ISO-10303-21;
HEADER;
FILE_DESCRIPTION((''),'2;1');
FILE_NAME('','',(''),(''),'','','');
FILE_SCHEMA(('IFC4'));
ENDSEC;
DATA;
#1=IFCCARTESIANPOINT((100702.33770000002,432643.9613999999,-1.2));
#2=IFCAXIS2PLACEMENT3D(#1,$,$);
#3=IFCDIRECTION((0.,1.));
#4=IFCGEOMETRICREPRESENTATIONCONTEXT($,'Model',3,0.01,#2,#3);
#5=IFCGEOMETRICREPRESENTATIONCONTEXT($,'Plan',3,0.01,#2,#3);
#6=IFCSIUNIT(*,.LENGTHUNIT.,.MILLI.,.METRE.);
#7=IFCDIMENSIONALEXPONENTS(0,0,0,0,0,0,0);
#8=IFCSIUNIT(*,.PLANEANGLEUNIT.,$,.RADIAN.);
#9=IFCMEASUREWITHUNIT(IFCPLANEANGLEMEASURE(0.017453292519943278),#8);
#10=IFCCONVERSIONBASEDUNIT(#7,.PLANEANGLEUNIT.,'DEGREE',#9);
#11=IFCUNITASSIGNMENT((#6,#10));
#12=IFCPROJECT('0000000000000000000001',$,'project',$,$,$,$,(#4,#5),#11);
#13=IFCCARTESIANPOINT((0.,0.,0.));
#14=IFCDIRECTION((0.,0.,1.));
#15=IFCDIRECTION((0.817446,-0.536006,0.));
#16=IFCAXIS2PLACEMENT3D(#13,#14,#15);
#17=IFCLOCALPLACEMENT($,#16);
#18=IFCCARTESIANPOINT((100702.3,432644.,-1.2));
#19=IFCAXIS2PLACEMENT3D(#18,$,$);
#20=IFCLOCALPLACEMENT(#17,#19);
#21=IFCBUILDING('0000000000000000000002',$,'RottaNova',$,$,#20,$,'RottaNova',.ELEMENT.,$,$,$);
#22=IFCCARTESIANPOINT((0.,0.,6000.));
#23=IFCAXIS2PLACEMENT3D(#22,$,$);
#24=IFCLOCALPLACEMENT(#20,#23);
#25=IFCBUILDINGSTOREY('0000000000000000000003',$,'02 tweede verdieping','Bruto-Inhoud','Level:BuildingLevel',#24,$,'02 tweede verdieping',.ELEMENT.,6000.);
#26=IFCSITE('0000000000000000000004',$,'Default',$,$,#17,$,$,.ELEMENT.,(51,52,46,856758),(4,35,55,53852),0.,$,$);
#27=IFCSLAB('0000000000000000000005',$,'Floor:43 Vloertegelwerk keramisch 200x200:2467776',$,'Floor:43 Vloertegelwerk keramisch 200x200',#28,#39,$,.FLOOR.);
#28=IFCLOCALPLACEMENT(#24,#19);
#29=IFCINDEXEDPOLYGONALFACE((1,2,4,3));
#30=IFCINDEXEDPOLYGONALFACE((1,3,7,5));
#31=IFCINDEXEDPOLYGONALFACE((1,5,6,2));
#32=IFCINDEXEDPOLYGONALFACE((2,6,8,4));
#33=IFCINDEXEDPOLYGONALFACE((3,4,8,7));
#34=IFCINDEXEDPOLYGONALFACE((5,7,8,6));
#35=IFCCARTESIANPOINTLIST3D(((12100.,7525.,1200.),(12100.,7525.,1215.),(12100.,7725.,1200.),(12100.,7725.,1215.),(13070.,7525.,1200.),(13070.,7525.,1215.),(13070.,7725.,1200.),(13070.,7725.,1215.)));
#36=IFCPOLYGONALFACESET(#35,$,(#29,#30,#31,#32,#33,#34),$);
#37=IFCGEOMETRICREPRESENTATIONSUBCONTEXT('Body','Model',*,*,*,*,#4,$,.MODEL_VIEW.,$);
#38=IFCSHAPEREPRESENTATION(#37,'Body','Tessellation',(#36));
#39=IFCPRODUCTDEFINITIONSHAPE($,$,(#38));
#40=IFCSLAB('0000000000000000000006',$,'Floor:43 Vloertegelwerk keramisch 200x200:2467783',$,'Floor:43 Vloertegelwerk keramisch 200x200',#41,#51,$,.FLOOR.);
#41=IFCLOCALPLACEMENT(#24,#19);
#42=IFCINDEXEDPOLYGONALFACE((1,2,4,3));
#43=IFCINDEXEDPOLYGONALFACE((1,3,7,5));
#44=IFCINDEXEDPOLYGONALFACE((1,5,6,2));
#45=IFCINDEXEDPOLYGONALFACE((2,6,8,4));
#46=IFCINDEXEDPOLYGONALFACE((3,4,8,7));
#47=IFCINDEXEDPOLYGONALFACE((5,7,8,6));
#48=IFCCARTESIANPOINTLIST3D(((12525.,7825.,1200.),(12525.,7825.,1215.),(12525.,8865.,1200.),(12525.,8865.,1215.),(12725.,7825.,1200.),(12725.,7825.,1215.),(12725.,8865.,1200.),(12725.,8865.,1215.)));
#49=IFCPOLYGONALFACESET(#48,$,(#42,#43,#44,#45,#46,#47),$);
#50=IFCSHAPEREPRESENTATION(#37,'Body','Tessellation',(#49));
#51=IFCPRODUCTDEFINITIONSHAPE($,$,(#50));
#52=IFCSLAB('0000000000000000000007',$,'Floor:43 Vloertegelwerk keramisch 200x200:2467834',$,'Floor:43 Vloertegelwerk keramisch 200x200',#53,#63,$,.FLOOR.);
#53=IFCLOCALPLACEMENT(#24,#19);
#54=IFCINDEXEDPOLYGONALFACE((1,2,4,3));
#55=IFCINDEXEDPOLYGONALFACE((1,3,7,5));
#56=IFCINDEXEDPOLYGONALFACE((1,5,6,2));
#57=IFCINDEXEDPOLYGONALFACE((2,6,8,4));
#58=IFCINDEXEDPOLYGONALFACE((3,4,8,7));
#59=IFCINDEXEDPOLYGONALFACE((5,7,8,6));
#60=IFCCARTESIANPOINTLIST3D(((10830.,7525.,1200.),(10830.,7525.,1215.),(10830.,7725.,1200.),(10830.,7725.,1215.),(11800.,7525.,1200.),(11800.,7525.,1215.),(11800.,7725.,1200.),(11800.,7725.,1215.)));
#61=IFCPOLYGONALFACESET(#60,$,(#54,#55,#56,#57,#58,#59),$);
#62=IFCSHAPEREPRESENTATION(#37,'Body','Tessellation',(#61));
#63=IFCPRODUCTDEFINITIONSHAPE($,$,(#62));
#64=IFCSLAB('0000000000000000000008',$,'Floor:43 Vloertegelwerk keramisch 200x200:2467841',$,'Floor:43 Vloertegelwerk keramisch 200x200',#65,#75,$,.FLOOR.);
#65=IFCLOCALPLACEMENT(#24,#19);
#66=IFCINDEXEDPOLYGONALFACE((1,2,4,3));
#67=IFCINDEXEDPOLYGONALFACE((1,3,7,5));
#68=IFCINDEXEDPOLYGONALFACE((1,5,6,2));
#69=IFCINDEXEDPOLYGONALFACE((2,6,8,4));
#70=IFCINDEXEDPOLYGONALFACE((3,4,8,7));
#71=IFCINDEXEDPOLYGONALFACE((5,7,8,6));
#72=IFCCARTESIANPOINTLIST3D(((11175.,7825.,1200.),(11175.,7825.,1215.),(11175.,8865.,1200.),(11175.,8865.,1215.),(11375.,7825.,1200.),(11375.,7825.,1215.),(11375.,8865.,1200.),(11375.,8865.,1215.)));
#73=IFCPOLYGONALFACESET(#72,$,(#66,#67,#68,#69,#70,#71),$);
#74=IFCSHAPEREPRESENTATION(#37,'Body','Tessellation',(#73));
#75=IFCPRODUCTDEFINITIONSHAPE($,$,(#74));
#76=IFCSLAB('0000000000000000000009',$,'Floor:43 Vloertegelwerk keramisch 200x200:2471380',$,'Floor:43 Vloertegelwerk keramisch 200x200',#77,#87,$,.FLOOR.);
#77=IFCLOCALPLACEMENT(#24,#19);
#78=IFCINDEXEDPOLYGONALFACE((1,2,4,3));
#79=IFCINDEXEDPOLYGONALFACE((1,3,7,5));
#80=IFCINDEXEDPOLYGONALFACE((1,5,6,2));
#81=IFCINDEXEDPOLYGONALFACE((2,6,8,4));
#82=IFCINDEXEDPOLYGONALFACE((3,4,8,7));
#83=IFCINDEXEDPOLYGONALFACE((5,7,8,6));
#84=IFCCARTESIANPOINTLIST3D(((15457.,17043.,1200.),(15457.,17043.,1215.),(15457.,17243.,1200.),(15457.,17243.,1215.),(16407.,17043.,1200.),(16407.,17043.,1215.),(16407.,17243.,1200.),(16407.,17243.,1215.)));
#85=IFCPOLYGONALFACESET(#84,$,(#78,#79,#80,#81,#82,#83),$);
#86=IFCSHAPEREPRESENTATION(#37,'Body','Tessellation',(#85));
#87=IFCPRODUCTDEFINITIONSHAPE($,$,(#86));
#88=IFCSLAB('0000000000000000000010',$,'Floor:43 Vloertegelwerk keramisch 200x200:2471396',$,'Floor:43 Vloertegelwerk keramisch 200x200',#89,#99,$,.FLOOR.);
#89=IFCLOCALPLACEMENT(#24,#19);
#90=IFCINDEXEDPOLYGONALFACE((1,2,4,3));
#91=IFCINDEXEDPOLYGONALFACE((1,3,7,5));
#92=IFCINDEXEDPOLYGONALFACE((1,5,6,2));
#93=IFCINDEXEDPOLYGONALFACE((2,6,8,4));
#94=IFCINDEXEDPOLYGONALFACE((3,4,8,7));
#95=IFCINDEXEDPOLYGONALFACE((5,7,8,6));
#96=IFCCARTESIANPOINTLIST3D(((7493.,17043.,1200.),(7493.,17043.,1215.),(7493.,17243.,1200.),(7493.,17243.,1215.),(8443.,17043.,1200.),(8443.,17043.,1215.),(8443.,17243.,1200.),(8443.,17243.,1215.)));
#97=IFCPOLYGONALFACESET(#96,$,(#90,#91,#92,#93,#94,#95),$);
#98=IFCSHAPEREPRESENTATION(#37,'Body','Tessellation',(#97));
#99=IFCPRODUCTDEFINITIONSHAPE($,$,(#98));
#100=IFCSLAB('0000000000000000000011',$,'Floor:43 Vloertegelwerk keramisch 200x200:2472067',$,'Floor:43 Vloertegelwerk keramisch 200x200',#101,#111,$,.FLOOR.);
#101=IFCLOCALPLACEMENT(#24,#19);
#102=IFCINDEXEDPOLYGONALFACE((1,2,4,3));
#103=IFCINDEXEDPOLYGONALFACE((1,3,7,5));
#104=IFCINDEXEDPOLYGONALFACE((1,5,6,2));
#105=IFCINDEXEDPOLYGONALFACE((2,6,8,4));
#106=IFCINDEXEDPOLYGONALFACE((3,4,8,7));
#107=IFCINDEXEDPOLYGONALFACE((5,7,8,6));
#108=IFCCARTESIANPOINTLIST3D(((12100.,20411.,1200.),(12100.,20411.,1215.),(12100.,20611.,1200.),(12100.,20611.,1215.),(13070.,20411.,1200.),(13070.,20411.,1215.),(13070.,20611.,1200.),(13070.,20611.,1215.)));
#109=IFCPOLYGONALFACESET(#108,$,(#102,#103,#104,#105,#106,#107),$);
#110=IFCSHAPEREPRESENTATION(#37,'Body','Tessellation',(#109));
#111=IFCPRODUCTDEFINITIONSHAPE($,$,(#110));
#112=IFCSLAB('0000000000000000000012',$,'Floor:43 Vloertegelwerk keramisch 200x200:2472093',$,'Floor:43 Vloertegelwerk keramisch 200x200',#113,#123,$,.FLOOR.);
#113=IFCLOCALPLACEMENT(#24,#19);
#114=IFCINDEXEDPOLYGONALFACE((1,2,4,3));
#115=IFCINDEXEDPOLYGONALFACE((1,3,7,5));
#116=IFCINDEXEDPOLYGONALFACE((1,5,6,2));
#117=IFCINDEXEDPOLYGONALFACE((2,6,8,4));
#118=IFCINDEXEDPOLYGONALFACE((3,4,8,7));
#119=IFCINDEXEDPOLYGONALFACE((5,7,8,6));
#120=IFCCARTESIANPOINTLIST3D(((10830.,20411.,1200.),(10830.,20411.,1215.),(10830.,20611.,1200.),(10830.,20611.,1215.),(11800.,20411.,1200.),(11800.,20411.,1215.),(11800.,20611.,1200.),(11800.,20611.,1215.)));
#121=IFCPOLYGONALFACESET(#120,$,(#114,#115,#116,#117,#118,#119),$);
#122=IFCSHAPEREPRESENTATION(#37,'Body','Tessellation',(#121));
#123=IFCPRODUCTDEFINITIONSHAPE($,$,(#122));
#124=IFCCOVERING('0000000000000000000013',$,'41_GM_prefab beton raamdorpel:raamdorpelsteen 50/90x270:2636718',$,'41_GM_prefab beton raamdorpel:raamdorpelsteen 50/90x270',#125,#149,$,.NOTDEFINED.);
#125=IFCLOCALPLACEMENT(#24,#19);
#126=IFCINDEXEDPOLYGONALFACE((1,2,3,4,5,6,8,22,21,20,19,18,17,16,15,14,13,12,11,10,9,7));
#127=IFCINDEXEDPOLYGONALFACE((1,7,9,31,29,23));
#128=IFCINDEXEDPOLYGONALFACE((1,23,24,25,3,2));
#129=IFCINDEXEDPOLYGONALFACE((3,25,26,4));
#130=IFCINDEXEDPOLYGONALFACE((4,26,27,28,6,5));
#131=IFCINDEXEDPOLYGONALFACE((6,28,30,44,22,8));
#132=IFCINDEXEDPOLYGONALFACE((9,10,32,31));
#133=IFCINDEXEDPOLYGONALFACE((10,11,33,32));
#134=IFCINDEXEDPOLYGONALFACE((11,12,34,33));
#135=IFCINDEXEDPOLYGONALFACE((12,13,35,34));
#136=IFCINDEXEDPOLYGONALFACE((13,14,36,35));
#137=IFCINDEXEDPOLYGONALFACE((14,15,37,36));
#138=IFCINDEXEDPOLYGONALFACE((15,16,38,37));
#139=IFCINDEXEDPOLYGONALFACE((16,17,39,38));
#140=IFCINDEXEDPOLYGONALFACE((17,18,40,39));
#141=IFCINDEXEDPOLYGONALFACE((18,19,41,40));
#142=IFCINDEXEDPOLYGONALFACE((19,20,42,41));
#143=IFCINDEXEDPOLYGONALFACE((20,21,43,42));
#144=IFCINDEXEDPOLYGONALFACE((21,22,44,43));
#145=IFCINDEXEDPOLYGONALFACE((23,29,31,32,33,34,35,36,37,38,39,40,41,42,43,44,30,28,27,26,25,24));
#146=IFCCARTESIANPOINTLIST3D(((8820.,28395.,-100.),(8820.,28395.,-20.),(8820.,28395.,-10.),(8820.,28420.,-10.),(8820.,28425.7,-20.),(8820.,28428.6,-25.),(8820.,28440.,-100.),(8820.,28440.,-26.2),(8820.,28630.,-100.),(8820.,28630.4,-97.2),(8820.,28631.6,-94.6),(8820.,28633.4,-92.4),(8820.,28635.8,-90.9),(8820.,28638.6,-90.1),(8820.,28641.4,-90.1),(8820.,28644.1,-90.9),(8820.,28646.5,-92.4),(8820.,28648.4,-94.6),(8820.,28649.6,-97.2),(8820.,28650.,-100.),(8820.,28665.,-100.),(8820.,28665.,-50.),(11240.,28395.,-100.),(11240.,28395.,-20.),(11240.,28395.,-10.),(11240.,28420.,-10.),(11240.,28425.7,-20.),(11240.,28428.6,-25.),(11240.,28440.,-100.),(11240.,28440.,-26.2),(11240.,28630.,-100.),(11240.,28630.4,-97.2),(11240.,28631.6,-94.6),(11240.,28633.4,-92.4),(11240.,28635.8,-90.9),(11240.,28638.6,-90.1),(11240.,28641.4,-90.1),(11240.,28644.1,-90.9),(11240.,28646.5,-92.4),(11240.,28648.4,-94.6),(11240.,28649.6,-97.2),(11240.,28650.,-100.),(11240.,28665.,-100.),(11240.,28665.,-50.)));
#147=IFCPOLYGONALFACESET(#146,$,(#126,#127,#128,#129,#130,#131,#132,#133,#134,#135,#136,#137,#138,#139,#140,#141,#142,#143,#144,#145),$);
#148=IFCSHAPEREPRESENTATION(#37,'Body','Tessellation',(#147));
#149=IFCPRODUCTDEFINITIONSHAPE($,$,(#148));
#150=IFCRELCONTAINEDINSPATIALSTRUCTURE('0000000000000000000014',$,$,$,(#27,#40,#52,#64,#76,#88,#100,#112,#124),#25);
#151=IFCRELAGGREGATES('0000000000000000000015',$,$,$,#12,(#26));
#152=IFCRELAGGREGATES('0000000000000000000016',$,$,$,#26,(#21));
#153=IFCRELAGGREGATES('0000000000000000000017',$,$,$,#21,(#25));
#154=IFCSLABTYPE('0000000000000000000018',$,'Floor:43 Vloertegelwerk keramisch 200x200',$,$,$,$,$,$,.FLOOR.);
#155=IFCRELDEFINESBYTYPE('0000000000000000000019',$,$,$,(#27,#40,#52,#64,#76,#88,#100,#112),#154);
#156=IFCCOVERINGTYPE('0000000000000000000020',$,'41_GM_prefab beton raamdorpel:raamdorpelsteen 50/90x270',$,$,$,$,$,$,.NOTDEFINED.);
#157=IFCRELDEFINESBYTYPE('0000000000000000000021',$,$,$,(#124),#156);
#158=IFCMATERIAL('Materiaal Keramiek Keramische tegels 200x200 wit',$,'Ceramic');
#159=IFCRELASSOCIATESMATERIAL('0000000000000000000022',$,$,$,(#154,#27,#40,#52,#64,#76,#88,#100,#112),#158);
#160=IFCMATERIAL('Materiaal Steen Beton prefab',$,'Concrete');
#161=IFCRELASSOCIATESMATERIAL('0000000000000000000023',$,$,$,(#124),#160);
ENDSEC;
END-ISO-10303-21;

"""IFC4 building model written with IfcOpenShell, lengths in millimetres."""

from ifc_helpers import new_model, entity, si_unit, converted_unit, direction, frame, place, context, subcontext, project, spatial, line, arc, indexed_curve, outline, extrude, material, type_object, element, save


model = new_model("IFC4")

# Units and contexts
model_context = context("Model", 3, precision=0.01, world=frame((100702.33770000002, 432643.9613999999, -1.2)), true_north=direction((0.0, 1.0)))
plan_context = context("Plan", 3, precision=0.01, world=frame((100702.33770000002, 432643.9613999999, -1.2)), true_north=direction((0.0, 1.0)))
body_context = subcontext(model_context, "Body", "Model", "MODEL_VIEW")
ifc_project = project(units=[si_unit("LENGTHUNIT", "METRE", prefix="MILLI"), converted_unit("PLANEANGLEUNIT", "DEGREE", entity("IfcPlaneAngleMeasure", 0.017453292519943278), si_unit("PLANEANGLEUNIT", "RADIAN"), dimensions=[0, 0, 0, 0, 0, 0, 0])], contexts=[model_context, plan_context])

# Site, building, storey
site_placement = place(None, frame((0.0, 0.0, 0.0), z_axis=(0.0, 0.0, 1.0), x_axis=(0.817446, -0.536006, 0.0)))
site = spatial("IfcSite", under=ifc_project, at=site_placement, Name="Default", CompositionType="ELEMENT", RefLatitude=(51, 52, 46, 856758), RefLongitude=(4, 35, 55, 53852), RefElevation=0.0)
building_placement = place(site_placement, frame((100702.3, 432644.0, -1.2)))
building = spatial("IfcBuilding", under=site, at=building_placement, Name="RottaNova", LongName="RottaNova", CompositionType="ELEMENT")
storey_placement = place(building_placement, frame((0.0, 0.0, 6000.0)))
storey = spatial("IfcBuildingStorey", under=building, at=storey_placement, Name="02 tweede verdieping", Description="Bruto-Inhoud", ObjectType="Level:BuildingLevel", LongName="02 tweede verdieping", CompositionType="ELEMENT", Elevation=6000.0)

# Shared definitions
ifc_material_1 = material(Name="Materiaal Steen Beton prefab", Category="Concrete")

# Slabs
ifc_material_2 = material(Name="Materiaal Keramiek Keramische tegels 200x200 wit", Category="Ceramic")
slab_type_1 = type_object("IfcSlabType", Name="Floor:43 Vloertegelwerk keramisch 200x200", PredefinedType="FLOOR", material=ifc_material_2)
slab_1_placement = place(storey_placement, frame((100702.3, 432644.0, -1.2)))
element("IfcSlab", 1, at=slab_1_placement, inside=storey, type_object=slab_type_1, material=ifc_material_2, Name="Floor:43 Vloertegelwerk keramisch 200x200:2467776", ObjectType="Floor:43 Vloertegelwerk keramisch 200x200", PredefinedType="FLOOR", context=body_context, shape_type="SweptSolid", body=[
    extrude(outline(indexed_curve([(-100.0, -485.0), (100.0, -485.0), (100.0, 485.0), (-100.0, 485.0), (-100.0, -485.0)], self_intersect=False)), frame((12585.0, 7625.0, 1215.0), z_axis=(0.0, 0.0, -1.0), x_axis=(0.0, 1.0, 0.0)), (0.0, 0.0, 1.0), 15.0),
])
slab_2_placement = place(storey_placement, frame((100702.3, 432644.0, -1.2)))
element("IfcSlab", 2, at=slab_2_placement, inside=storey, type_object=slab_type_1, material=ifc_material_2, Name="Floor:43 Vloertegelwerk keramisch 200x200:2467783", ObjectType="Floor:43 Vloertegelwerk keramisch 200x200", PredefinedType="FLOOR", context=body_context, shape_type="SweptSolid", body=[
    extrude(outline(indexed_curve([(-520.0, -100.0), (520.0, -100.0), (520.0, 100.0), (-520.0, 100.0), (-520.0, -100.0)], self_intersect=False)), frame((12625.0, 8345.0, 1215.0), z_axis=(0.0, 0.0, -1.0), x_axis=(0.0, 1.0, 0.0)), (0.0, 0.0, 1.0), 15.0),
])
slab_3_placement = place(storey_placement, frame((100702.3, 432644.0, -1.2)))
element("IfcSlab", 3, at=slab_3_placement, inside=storey, type_object=slab_type_1, material=ifc_material_2, Name="Floor:43 Vloertegelwerk keramisch 200x200:2467834", ObjectType="Floor:43 Vloertegelwerk keramisch 200x200", PredefinedType="FLOOR", context=body_context, shape_type="SweptSolid", body=[
    extrude(outline(indexed_curve([(-100.0, -485.0), (100.0, -485.0), (100.0, 485.0), (-100.0, 485.0), (-100.0, -485.0)], self_intersect=False)), frame((11315.0, 7625.0, 1215.0), z_axis=(0.0, 0.0, -1.0), x_axis=(0.0, 1.0, 0.0)), (0.0, 0.0, 1.0), 15.0),
])
slab_4_placement = place(storey_placement, frame((100702.3, 432644.0, -1.2)))
element("IfcSlab", 4, at=slab_4_placement, inside=storey, type_object=slab_type_1, material=ifc_material_2, Name="Floor:43 Vloertegelwerk keramisch 200x200:2467841", ObjectType="Floor:43 Vloertegelwerk keramisch 200x200", PredefinedType="FLOOR", context=body_context, shape_type="SweptSolid", body=[
    extrude(outline(indexed_curve([(-520.0, -100.0), (520.0, -100.0), (520.0, 100.0), (-520.0, 100.0), (-520.0, -100.0)], self_intersect=False)), frame((11275.0, 8345.0, 1215.0), z_axis=(0.0, 0.0, -1.0), x_axis=(0.0, 1.0, 0.0)), (0.0, 0.0, 1.0), 15.0),
])
slab_5_placement = place(storey_placement, frame((100702.3, 432644.0, -1.2)))
element("IfcSlab", 5, at=slab_5_placement, inside=storey, type_object=slab_type_1, material=ifc_material_2, Name="Floor:43 Vloertegelwerk keramisch 200x200:2471380", ObjectType="Floor:43 Vloertegelwerk keramisch 200x200", PredefinedType="FLOOR", context=body_context, shape_type="SweptSolid", body=[
    extrude(outline(indexed_curve([(-100.0, -475.0), (100.0, -475.0), (100.0, 475.0), (-100.0, 475.0), (-100.0, -475.0)], self_intersect=False)), frame((15932.0, 17143.0, 1215.0), z_axis=(0.0, 0.0, -1.0), x_axis=(0.0, 1.0, 0.0)), (0.0, 0.0, 1.0), 15.0),
])
slab_6_placement = place(storey_placement, frame((100702.3, 432644.0, -1.2)))
element("IfcSlab", 6, at=slab_6_placement, inside=storey, type_object=slab_type_1, material=ifc_material_2, Name="Floor:43 Vloertegelwerk keramisch 200x200:2471396", ObjectType="Floor:43 Vloertegelwerk keramisch 200x200", PredefinedType="FLOOR", context=body_context, shape_type="SweptSolid", body=[
    extrude(outline(indexed_curve([(-100.0, -475.0), (100.0, -475.0), (100.0, 475.0), (-100.0, 475.0), (-100.0, -475.0)], self_intersect=False)), frame((7968.0, 17143.0, 1215.0), z_axis=(0.0, 0.0, -1.0), x_axis=(0.0, 1.0, 0.0)), (0.0, 0.0, 1.0), 15.0),
])
slab_7_placement = place(storey_placement, frame((100702.3, 432644.0, -1.2)))
element("IfcSlab", 7, at=slab_7_placement, inside=storey, type_object=slab_type_1, material=ifc_material_2, Name="Floor:43 Vloertegelwerk keramisch 200x200:2472067", ObjectType="Floor:43 Vloertegelwerk keramisch 200x200", PredefinedType="FLOOR", context=body_context, shape_type="SweptSolid", body=[
    extrude(outline(indexed_curve([(-100.0, -485.0), (100.0, -485.0), (100.0, 485.0), (-100.0, 485.0), (-100.0, -485.0)], self_intersect=False)), frame((12585.0, 20511.0, 1215.0), z_axis=(0.0, 0.0, -1.0), x_axis=(0.0, 1.0, 0.0)), (0.0, 0.0, 1.0), 15.0),
])
slab_8_placement = place(storey_placement, frame((100702.3, 432644.0, -1.2)))
element("IfcSlab", 8, at=slab_8_placement, inside=storey, type_object=slab_type_1, material=ifc_material_2, Name="Floor:43 Vloertegelwerk keramisch 200x200:2472093", ObjectType="Floor:43 Vloertegelwerk keramisch 200x200", PredefinedType="FLOOR", context=body_context, shape_type="SweptSolid", body=[
    extrude(outline(indexed_curve([(-100.0, -485.0), (100.0, -485.0), (100.0, 485.0), (-100.0, 485.0), (-100.0, -485.0)], self_intersect=False)), frame((11315.0, 20511.0, 1215.0), z_axis=(0.0, 0.0, -1.0), x_axis=(0.0, 1.0, 0.0)), (0.0, 0.0, 1.0), 15.0),
])

# Covering
covering_type_1 = type_object("IfcCoveringType", Name="41_GM_prefab beton raamdorpel:raamdorpelsteen 50/90x270", PredefinedType="NOTDEFINED")
covering_1_placement = place(storey_placement, frame((100702.3, 432644.0, -1.2)))
element("IfcCovering", 9, at=covering_1_placement, inside=storey, type_object=covering_type_1, material=ifc_material_1, Name="41_GM_prefab beton raamdorpel:raamdorpelsteen 50/90x270:2636718", ObjectType="41_GM_prefab beton raamdorpel:raamdorpelsteen 50/90x270", PredefinedType="NOTDEFINED", context=body_context, shape_type="SweptSolid", body=[
    extrude(outline(indexed_curve([(75.8, -45.1), (100.8, -45.1), (100.8, -35.1), (100.8, 44.9), (55.8, 44.9), (-134.2, 44.9), (-144.2, 34.9), (-154.2, 44.9), (-169.2, 44.9), (-169.2, -5.1), (55.8, -28.9), (67.1, -30.1), (70.0, -35.1)], segments=[line(1, 2, 3, 4, 5, 6), arc(6, 7, 8), line(8, 9, 10, 11, 12, 13, 1)], self_intersect=False)), frame((8820.0, 28495.8, -55.1), z_axis=(1.0, 0.0, 0.0), x_axis=(0.0, -1.0, 0.0)), (0.0, 0.0, 1.0), 2420.0),
])

save(model, "model.ifc")
